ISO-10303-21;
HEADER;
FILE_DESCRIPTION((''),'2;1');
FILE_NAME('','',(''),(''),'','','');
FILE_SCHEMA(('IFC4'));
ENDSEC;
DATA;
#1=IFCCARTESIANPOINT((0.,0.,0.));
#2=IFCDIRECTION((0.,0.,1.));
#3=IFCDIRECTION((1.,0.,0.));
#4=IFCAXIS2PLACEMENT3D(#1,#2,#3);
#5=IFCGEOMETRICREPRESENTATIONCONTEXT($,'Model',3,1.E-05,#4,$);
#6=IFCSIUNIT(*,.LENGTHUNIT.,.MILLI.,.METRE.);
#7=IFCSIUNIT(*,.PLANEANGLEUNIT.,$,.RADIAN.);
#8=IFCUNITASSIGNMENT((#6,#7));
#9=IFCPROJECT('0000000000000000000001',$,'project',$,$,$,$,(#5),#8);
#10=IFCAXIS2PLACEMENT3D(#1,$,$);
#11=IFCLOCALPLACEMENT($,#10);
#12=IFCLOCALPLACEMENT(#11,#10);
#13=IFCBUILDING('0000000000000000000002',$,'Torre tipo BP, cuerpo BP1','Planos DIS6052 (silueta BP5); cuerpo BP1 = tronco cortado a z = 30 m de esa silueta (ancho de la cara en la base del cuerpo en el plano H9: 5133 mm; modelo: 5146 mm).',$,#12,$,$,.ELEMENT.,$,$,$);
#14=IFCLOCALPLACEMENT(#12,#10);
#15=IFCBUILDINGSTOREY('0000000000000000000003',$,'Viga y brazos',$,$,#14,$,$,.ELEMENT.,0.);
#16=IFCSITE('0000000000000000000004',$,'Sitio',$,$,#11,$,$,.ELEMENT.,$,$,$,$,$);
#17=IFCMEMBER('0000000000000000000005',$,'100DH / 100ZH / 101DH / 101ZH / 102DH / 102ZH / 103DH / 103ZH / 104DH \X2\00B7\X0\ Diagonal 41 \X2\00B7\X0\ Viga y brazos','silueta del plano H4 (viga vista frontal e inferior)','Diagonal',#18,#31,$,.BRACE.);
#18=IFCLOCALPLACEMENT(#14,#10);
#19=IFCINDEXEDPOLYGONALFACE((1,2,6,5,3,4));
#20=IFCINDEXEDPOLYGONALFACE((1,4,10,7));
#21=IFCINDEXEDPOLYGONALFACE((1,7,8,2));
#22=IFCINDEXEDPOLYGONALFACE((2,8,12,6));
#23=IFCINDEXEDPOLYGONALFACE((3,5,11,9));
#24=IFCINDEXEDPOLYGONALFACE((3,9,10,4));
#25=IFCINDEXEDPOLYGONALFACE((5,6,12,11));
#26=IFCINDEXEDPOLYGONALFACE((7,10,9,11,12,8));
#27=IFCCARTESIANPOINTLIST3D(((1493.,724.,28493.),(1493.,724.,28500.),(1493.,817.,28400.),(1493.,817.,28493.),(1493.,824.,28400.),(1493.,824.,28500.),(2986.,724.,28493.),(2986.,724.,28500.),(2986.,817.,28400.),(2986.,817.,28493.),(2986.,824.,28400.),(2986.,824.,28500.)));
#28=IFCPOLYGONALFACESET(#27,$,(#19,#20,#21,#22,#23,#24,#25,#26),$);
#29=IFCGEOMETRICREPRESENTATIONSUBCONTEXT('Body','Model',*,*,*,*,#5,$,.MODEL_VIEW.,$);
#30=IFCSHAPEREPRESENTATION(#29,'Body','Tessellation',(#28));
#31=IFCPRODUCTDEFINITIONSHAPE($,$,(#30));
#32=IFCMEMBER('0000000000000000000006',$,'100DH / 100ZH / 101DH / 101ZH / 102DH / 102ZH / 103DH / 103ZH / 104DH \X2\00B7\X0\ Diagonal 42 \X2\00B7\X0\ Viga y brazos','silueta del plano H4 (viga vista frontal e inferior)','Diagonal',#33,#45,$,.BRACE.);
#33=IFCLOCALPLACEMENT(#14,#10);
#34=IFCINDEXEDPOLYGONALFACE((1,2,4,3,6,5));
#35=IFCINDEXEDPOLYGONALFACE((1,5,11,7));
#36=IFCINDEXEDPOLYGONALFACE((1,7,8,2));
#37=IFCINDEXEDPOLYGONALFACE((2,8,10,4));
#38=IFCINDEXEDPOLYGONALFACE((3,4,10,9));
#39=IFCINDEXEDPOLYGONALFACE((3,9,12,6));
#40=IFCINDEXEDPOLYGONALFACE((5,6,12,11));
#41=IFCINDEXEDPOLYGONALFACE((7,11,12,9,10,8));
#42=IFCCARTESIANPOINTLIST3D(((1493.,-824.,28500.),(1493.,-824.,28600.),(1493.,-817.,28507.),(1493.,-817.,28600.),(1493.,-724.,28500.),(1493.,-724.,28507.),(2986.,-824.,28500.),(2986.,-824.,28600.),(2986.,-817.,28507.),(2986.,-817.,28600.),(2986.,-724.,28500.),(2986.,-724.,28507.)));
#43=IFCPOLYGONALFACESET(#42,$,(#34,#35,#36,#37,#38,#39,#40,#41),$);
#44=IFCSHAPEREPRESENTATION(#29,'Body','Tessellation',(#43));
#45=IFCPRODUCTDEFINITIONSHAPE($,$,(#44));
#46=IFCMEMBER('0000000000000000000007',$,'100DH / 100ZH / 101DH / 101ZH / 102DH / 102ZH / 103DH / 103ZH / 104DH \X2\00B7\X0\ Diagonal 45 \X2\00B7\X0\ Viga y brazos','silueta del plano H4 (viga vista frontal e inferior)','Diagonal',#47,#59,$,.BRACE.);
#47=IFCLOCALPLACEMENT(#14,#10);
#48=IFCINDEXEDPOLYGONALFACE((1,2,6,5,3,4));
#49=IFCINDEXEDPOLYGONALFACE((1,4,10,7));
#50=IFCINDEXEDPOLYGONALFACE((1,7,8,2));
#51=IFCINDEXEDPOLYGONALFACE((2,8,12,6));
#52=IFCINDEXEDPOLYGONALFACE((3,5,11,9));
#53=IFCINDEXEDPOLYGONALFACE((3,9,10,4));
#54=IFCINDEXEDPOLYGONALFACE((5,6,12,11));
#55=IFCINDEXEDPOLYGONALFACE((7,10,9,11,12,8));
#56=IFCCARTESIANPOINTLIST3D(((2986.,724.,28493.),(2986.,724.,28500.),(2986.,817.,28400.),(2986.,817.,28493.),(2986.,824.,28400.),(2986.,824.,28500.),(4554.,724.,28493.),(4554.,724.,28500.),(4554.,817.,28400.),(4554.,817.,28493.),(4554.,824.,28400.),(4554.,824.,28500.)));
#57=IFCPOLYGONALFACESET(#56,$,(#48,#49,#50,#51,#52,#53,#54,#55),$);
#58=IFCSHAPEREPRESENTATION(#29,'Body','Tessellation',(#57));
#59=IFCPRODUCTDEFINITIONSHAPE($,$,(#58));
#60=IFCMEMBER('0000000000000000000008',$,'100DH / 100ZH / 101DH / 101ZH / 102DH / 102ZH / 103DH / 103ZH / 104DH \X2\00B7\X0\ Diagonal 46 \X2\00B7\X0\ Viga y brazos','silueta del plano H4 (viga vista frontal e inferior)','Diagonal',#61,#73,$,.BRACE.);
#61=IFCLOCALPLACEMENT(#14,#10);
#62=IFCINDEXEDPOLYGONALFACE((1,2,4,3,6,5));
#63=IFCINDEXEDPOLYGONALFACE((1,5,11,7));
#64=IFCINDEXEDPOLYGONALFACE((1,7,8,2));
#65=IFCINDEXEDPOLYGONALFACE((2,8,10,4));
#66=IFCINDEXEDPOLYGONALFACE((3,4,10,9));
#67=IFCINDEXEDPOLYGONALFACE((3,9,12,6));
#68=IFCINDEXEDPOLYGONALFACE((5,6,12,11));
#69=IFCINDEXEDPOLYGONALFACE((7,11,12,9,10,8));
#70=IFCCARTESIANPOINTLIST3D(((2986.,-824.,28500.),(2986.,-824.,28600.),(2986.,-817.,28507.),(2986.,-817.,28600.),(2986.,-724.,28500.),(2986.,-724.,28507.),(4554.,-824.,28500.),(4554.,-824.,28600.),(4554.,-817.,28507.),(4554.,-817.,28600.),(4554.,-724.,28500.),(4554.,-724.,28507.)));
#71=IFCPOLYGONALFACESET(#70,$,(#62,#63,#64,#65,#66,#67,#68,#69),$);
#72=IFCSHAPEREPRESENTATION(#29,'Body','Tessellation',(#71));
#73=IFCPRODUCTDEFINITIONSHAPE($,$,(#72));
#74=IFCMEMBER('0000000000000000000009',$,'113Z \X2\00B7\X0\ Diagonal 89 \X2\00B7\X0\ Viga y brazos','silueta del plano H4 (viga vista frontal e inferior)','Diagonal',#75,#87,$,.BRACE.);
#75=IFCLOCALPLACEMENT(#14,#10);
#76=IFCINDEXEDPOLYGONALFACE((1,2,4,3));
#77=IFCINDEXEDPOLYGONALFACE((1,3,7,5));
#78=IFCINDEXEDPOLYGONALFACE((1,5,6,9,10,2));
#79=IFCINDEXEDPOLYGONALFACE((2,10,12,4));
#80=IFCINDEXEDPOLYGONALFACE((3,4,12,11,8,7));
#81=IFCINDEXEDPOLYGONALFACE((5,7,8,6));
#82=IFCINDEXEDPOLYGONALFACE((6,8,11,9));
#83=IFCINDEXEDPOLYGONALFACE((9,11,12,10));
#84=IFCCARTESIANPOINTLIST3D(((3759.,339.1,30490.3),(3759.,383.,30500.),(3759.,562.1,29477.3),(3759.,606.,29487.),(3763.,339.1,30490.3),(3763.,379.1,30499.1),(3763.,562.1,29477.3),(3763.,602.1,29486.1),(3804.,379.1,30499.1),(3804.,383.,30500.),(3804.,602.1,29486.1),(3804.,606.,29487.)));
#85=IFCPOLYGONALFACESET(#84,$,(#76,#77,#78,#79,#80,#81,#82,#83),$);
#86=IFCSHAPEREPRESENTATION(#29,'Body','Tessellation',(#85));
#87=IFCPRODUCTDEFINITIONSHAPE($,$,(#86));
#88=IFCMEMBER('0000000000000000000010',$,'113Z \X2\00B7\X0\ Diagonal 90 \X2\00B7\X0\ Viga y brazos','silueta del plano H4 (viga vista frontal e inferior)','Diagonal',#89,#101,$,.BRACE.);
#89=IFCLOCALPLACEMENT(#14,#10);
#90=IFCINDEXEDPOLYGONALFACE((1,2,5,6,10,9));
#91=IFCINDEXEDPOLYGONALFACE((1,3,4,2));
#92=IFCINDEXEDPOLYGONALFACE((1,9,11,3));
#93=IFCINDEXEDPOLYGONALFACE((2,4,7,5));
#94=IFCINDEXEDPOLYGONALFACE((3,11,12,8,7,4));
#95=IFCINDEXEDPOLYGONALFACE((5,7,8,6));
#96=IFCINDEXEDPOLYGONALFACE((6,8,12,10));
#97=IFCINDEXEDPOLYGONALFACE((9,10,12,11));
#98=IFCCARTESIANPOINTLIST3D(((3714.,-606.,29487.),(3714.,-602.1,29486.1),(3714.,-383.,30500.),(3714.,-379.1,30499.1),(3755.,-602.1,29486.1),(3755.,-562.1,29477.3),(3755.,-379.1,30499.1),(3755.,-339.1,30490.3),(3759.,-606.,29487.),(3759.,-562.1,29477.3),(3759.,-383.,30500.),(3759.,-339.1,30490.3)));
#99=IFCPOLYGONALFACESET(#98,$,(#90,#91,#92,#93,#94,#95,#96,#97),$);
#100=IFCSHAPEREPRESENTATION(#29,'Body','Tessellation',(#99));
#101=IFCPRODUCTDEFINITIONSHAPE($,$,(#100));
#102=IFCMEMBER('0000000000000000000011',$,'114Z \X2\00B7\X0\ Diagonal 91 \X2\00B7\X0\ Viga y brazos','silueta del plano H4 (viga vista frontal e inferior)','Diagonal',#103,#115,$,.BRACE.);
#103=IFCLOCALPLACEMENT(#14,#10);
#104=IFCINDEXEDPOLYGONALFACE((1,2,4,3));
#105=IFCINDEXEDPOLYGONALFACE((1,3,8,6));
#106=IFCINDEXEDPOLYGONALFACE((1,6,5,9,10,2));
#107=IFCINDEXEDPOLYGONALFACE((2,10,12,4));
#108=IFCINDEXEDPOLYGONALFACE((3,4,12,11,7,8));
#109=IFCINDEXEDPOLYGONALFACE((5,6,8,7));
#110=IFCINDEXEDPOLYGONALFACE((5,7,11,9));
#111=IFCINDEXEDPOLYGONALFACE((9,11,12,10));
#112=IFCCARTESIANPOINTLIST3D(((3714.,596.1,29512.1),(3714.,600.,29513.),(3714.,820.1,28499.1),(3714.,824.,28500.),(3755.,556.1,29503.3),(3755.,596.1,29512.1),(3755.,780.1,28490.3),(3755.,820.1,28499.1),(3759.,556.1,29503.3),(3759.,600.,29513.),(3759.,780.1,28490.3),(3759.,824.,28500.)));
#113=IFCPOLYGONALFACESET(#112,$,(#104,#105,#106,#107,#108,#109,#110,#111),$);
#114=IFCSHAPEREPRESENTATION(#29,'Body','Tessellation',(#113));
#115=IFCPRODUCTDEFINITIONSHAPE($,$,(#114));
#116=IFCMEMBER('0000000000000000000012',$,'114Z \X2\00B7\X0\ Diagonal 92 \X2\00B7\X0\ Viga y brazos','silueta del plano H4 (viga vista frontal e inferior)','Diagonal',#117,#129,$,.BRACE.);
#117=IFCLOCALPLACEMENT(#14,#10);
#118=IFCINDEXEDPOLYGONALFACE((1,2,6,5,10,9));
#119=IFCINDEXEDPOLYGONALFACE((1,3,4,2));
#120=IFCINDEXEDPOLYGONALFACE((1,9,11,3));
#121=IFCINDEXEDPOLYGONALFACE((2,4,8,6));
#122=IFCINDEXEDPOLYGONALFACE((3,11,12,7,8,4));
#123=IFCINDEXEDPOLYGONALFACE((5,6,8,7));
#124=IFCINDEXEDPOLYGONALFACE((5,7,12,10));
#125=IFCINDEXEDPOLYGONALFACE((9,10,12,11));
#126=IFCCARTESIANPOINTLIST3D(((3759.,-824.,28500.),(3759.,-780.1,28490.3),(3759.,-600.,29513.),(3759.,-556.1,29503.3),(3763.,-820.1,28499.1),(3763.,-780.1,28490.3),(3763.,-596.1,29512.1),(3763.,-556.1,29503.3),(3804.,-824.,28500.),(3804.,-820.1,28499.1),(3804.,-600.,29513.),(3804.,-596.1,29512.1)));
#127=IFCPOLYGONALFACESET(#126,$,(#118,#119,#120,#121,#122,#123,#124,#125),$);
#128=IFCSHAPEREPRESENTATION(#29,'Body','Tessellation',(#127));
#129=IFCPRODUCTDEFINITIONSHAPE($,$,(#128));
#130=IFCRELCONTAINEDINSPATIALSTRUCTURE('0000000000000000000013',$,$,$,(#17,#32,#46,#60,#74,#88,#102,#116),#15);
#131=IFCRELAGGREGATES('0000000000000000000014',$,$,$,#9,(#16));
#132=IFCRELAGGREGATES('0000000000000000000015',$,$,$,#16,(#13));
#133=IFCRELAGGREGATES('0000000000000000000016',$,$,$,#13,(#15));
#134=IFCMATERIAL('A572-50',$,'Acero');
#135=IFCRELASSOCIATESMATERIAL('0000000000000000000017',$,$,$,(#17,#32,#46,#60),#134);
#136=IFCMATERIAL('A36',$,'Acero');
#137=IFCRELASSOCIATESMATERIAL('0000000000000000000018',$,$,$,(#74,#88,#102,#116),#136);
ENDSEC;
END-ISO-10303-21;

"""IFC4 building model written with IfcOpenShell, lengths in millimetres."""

from ifc_helpers import new_model, si_unit, frame, frame_2d, origin, origin_with_axes, place, context, subcontext, project, spatial, l_section, extrude, material, element, save


model = new_model("IFC4")

# Units and contexts
model_context = context("Model", 3, precision=1e-05, world=origin_with_axes())
body_context = subcontext(model_context, "Body", "Model", "MODEL_VIEW")
ifc_project = project(units=[si_unit("LENGTHUNIT", "METRE", prefix="MILLI"), si_unit("PLANEANGLEUNIT", "RADIAN")], contexts=[model_context])

# Site, building, storey
site_placement = place(None, origin())
site = spatial("IfcSite", under=ifc_project, at=site_placement, Name="Sitio", CompositionType="ELEMENT")
building_placement = place(site_placement, origin())
building = spatial("IfcBuilding", under=site, at=building_placement, Name="Torre tipo BP, cuerpo BP1", Description="Planos DIS6052 (silueta BP5); cuerpo BP1 = tronco cortado a z = 30 m de esa silueta (ancho de la cara en la base del cuerpo en el plano H9: 5133 mm; modelo: 5146 mm).", CompositionType="ELEMENT")
storey_placement = place(building_placement, origin())
storey = spatial("IfcBuildingStorey", under=building, at=storey_placement, Name="Viga y brazos", CompositionType="ELEMENT", Elevation=0.0)

# Members
ifc_material_1 = material(Name="A572-50", Category="Acero")
ifc_material_2 = material(Name="A36", Category="Acero")
for number, where, z_axis, x_axis, name in (
    (1, (1493.0, 824.0, 28500.0), (1.0, 0.0, 0.0), (0.0, -1.0, 0.0), "100DH / 100ZH / 101DH / 101ZH / 102DH / 102ZH / 103DH / 103ZH / 104DH · Diagonal 41 · Viga y brazos"),
    (2, (1493.0, -824.0, 28500.0), (1.0, 0.0, 0.0), (0.0, 1.0, 0.0), "100DH / 100ZH / 101DH / 101ZH / 102DH / 102ZH / 103DH / 103ZH / 104DH · Diagonal 42 · Viga y brazos"),
):
    element("IfcMember", number, at=place(storey_placement, frame(where, z_axis=z_axis, x_axis=x_axis)), inside=storey, material=ifc_material_1, Name=name, Description="silueta del plano H4 (viga vista frontal e inferior)", ObjectType="Diagonal", PredefinedType="BRACE", context=body_context, shape_type="SweptSolid", body=[
        extrude(l_section(Depth=100.0, Width=100.0, Thickness=7.0, at=frame_2d((50.0, 50.0))), None, (0.0, 0.0, 1.0), 1493.0),
    ])
for number, where, z_axis, x_axis, name in (
    (3, (2986.0, 824.0, 28500.0), (1.0, 0.0, 0.0), (0.0, -1.0, 0.0), "100DH / 100ZH / 101DH / 101ZH / 102DH / 102ZH / 103DH / 103ZH / 104DH · Diagonal 45 · Viga y brazos"),
    (4, (2986.0, -824.0, 28500.0), (1.0, 0.0, 0.0), (0.0, 1.0, 0.0), "100DH / 100ZH / 101DH / 101ZH / 102DH / 102ZH / 103DH / 103ZH / 104DH · Diagonal 46 · Viga y brazos"),
):
    element("IfcMember", number, at=place(storey_placement, frame(where, z_axis=z_axis, x_axis=x_axis)), inside=storey, material=ifc_material_1, Name=name, Description="silueta del plano H4 (viga vista frontal e inferior)", ObjectType="Diagonal", PredefinedType="BRACE", context=body_context, shape_type="SweptSolid", body=[
        extrude(l_section(Depth=100.0, Width=100.0, Thickness=7.0, at=frame_2d((50.0, 50.0))), None, (0.0, 0.0, 1.0), 1568.0),
    ])
for number, where, z_axis, x_axis, name in (
    (5, (3759.0, 606.0, 29487.0), (0.0, -0.214991, 0.976616), (0.0, -0.976616, -0.214991), "113Z · Diagonal 89 · Viga y brazos"),
    (6, (3759.0, -606.0, 29487.0), (0.0, 0.214991, 0.976616), (0.0, 0.976616, -0.214991), "113Z · Diagonal 90 · Viga y brazos"),
):
    element("IfcMember", number, at=place(storey_placement, frame(where, z_axis=z_axis, x_axis=x_axis)), inside=storey, material=ifc_material_2, Name=name, Description="silueta del plano H4 (viga vista frontal e inferior)", ObjectType="Diagonal", PredefinedType="BRACE", context=body_context, shape_type="SweptSolid", body=[
        extrude(l_section(Depth=45.0, Width=45.0, Thickness=4.0, at=frame_2d((22.5, 22.5))), None, (0.0, 0.0, 1.0), 1037.3),
    ])
for number, where, z_axis, x_axis, name in (
    (7, (3759.0, 600.0, 29513.0), (0.0, 0.21591, -0.976413), (0.0, -0.976413, -0.21591), "114Z · Diagonal 91 · Viga y brazos"),
    (8, (3759.0, -600.0, 29513.0), (0.0, -0.21591, -0.976413), (0.0, 0.976413, -0.21591), "114Z · Diagonal 92 · Viga y brazos"),
):
    element("IfcMember", number, at=place(storey_placement, frame(where, z_axis=z_axis, x_axis=x_axis)), inside=storey, material=ifc_material_2, Name=name, Description="silueta del plano H4 (viga vista frontal e inferior)", ObjectType="Diagonal", PredefinedType="BRACE", context=body_context, shape_type="SweptSolid", body=[
        extrude(l_section(Depth=45.0, Width=45.0, Thickness=4.0, at=frame_2d((22.5, 22.5))), None, (0.0, 0.0, 1.0), 1037.5),
    ])

save(model, "model.ifc")
